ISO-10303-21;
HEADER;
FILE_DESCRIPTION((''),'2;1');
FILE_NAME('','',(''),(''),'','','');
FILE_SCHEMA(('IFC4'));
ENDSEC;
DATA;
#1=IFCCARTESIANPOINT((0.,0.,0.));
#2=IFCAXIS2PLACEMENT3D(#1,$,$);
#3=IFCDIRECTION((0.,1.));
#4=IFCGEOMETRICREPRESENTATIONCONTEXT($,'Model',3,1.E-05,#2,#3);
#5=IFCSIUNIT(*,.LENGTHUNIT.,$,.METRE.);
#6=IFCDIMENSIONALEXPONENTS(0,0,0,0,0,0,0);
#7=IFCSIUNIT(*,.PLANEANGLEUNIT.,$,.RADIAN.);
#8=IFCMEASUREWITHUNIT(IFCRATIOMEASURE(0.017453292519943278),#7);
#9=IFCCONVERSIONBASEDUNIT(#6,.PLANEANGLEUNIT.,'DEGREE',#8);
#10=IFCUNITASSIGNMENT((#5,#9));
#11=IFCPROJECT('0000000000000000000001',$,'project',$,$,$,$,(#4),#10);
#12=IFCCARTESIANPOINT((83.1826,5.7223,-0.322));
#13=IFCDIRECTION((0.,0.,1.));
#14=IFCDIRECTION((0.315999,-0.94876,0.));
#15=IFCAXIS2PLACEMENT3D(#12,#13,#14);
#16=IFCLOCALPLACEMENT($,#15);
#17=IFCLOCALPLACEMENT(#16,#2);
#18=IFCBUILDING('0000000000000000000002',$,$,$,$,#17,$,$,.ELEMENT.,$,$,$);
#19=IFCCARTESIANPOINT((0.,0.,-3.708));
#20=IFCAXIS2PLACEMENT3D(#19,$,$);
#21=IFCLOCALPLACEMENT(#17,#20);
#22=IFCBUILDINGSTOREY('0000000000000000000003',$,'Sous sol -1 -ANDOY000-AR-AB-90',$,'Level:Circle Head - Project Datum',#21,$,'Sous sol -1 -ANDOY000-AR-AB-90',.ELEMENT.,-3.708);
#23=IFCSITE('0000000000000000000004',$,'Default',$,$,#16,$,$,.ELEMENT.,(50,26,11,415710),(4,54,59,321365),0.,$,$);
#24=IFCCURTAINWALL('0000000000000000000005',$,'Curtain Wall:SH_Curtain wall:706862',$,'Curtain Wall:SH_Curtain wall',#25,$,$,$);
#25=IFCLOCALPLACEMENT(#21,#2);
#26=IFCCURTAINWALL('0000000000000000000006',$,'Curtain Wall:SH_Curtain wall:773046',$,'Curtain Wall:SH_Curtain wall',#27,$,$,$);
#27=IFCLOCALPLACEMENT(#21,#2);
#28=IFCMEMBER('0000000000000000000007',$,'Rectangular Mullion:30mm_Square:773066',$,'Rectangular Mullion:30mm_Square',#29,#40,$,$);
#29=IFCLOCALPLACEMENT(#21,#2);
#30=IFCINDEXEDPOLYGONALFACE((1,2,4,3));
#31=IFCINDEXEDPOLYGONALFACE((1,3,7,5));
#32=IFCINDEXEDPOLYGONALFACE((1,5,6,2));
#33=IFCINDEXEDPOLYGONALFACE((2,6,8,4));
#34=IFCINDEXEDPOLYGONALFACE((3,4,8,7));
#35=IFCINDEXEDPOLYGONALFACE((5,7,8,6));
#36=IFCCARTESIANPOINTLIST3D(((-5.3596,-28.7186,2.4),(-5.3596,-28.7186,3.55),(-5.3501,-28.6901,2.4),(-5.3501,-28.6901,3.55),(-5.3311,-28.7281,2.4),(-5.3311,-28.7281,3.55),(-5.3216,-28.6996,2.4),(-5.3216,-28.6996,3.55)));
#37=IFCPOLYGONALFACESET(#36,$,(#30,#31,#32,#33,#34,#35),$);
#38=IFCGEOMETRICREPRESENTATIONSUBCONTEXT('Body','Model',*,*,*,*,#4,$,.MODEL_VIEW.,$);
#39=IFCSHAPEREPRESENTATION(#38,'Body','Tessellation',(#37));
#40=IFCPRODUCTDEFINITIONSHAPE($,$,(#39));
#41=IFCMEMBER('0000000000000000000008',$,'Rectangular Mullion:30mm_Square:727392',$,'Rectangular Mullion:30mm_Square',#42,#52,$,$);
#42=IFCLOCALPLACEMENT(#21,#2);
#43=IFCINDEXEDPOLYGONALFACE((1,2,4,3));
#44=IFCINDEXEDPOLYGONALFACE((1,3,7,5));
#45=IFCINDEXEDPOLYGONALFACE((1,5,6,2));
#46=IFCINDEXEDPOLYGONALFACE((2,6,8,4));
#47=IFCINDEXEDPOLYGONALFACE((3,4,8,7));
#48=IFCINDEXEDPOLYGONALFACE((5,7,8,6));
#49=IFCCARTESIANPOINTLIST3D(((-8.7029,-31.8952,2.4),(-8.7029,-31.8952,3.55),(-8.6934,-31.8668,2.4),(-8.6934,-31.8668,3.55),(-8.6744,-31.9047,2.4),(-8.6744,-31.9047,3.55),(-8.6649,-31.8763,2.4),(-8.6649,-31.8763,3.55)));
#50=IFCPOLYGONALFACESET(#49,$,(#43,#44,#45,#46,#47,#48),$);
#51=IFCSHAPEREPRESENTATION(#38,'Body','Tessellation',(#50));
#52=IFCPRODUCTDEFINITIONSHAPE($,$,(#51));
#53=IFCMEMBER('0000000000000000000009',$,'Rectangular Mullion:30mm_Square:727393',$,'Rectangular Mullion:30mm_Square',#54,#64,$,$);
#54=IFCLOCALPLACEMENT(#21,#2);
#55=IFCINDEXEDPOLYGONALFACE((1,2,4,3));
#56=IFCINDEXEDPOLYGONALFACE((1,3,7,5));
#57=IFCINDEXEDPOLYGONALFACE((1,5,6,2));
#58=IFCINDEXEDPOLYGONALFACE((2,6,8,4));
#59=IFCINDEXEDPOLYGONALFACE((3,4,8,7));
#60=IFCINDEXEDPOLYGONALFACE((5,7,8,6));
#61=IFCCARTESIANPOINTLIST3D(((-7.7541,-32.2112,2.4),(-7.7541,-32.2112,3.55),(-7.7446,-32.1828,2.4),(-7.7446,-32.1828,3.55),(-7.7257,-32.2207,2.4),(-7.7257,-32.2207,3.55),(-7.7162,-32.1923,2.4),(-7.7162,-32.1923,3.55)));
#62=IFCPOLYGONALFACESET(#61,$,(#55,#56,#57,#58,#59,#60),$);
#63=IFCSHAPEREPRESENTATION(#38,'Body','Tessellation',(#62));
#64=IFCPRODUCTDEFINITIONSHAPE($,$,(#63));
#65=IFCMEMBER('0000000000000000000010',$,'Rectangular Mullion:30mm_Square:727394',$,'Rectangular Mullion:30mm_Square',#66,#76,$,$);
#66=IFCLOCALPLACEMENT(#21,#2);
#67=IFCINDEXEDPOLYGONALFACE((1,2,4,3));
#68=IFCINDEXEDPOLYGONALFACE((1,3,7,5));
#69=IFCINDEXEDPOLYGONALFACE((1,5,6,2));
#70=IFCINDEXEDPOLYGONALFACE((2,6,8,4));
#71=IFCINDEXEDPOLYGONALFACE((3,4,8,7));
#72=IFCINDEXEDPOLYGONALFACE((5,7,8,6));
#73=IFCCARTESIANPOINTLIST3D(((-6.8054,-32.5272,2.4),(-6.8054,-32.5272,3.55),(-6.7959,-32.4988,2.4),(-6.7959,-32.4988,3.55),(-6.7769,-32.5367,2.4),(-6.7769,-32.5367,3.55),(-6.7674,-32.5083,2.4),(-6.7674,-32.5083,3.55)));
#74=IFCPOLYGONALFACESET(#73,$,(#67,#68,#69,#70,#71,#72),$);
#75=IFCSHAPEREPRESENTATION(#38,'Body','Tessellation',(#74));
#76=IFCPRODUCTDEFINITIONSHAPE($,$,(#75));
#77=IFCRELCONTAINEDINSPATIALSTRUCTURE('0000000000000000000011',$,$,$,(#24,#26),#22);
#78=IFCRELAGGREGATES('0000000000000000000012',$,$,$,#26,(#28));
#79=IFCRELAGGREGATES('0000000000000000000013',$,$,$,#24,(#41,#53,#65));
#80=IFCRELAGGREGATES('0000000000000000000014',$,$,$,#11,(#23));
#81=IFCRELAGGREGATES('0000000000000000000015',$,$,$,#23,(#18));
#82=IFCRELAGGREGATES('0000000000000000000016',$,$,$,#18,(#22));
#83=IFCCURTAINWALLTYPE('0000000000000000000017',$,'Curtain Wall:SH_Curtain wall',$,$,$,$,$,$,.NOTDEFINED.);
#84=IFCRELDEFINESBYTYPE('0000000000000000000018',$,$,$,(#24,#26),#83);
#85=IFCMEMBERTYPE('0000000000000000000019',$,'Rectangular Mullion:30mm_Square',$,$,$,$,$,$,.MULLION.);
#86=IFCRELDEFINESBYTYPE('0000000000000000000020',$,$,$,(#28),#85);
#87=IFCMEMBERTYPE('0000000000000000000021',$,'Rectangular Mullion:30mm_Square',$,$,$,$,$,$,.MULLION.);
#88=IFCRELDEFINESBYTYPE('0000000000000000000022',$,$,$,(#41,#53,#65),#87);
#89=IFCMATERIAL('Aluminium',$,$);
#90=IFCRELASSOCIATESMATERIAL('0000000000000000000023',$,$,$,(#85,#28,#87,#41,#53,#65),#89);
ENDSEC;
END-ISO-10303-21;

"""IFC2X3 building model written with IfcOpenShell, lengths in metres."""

from ifc_helpers import new_model, entity, si_unit, converted_unit, direction, frame, origin, origin_2d_with_axis, place, context, subcontext, project, spatial, rectangle, extrude, source, transform, mapped, material, type_object, type_shapes, element, aggregate, save


model = new_model("IFC2X3")

# Units and contexts
model_context = context("Model", 3, precision=1e-05, world=origin(), true_north=direction((0.0, 1.0)))
body_context = subcontext(model_context, "Body", "Model", "MODEL_VIEW")
ifc_project = project(units=[si_unit("LENGTHUNIT", "METRE"), converted_unit("PLANEANGLEUNIT", "DEGREE", entity("IfcRatioMeasure", 0.017453292519943278), si_unit("PLANEANGLEUNIT", "RADIAN"), dimensions=[0, 0, 0, 0, 0, 0, 0])], contexts=[model_context])

# Site, building, storey
site_placement = place(None, frame((83.1826, 5.7223, -0.322), z_axis=(0.0, 0.0, 1.0), x_axis=(0.315999, -0.94876, 0.0)))
site = spatial("IfcSite", under=ifc_project, at=site_placement, Name="Default", CompositionType="ELEMENT", RefLatitude=(50, 26, 11, 415710), RefLongitude=(4, 54, 59, 321365), RefElevation=0.0)
building_placement = place(site_placement, origin())
building = spatial("IfcBuilding", under=site, at=building_placement, CompositionType="ELEMENT")
storey_placement = place(building_placement, frame((0.0, 0.0, -3.708)))
storey = spatial("IfcBuildingStorey", under=building, at=storey_placement, Name="Sous sol -1 -ANDOY000-AR-AB-90", ObjectType="Level:Circle Head - Project Datum", LongName="Sous sol -1 -ANDOY000-AR-AB-90", CompositionType="ELEMENT", Elevation=-3.708)

# Curtain wall
curtain_wall_type = type_object("IfcCurtainWallType", Name="Curtain Wall:SH_Curtain wall", PredefinedType="NOTDEFINED")
curtain_wall_1_placement = place(storey_placement, frame((0.0, 0.0, 3.708)))
curtain_wall_1 = element("IfcCurtainWall", 1, at=curtain_wall_1_placement, inside=storey, type_object=curtain_wall_type, Name="Curtain Wall:SH_Curtain wall:706862", ObjectType="Curtain Wall:SH_Curtain wall")
ifc_material_1 = material(Name="Aluminium")

# Curtain wall, member
curtain_wall_2_placement = place(storey_placement, frame((0.0, 0.0, 3.708)))
curtain_wall_2 = element("IfcCurtainWall", 2, at=curtain_wall_2_placement, inside=storey, type_object=curtain_wall_type, Name="Curtain Wall:SH_Curtain wall:773046", ObjectType="Curtain Wall:SH_Curtain wall")
member_type_1 = type_object("IfcMemberType", Name="Rectangular Mullion:30mm_Square", PredefinedType="MULLION", material=ifc_material_1)
shared_shape_1 = source(origin(), body_context, "Body", "SweptSolid", [
    extrude(rectangle(XDim=0.03, YDim=0.03, at=origin_2d_with_axis()), frame((-0.015, 0.0, -1.15), z_axis=(0.0, 0.0, 1.0), x_axis=(0.0, -1.0, 0.0)), (0.0, 0.0, 1.0), 1.15),
])
type_shapes(member_type_1, [shared_shape_1])
member_1_placement = place(curtain_wall_2_placement, frame((-5.3264, -28.7138, -1.308), z_axis=(0.0, 0.0, -1.0), x_axis=(0.948759, -0.316, 0.0)))
member_1 = element("IfcMember", 3, at=member_1_placement, type_object=member_type_1, material=ifc_material_1, Name="Rectangular Mullion:30mm_Square:773066", ObjectType="Rectangular Mullion:30mm_Square", context=body_context, shape_type="MappedRepresentation", body=[
    mapped(shared_shape_1, transform((0.0, 0.0, 0.0), scale=1.0)),
])
aggregate(curtain_wall_2, [member_1])

# Members
member_type_2 = type_object("IfcMemberType", Name="Rectangular Mullion:30mm_Square", PredefinedType="MULLION", material=ifc_material_1)
shared_shape_2 = source(origin(), body_context, "Body", "SweptSolid", [
    extrude(rectangle(XDim=0.03, YDim=0.03, at=origin_2d_with_axis()), frame((0.0, 0.0, -1.15), z_axis=(0.0, 0.0, 1.0), x_axis=(0.0, -1.0, 0.0)), (0.0, 0.0, 1.0), 1.15),
])
type_shapes(member_type_2, [shared_shape_2])
member_2_placement = place(curtain_wall_1_placement, frame((-8.6839, -31.8858, -1.308), z_axis=(0.0, 0.0, -1.0), x_axis=(0.948759, -0.316, 0.0)))
member_2 = element("IfcMember", 4, at=member_2_placement, type_object=member_type_2, material=ifc_material_1, Name="Rectangular Mullion:30mm_Square:727392", ObjectType="Rectangular Mullion:30mm_Square", context=body_context, shape_type="MappedRepresentation", body=[
    mapped(shared_shape_2, transform((0.0, 0.0, 0.0), scale=1.0)),
])
member_3_placement = place(curtain_wall_1_placement, frame((-7.7351, -32.2018, -1.308), z_axis=(0.0, 0.0, -1.0), x_axis=(0.948759, -0.316, 0.0)))
member_3 = element("IfcMember", 5, at=member_3_placement, type_object=member_type_2, material=ifc_material_1, Name="Rectangular Mullion:30mm_Square:727393", ObjectType="Rectangular Mullion:30mm_Square", context=body_context, shape_type="MappedRepresentation", body=[
    mapped(shared_shape_2, transform((0.0, 0.0, 0.0), scale=1.0)),
])
member_4_placement = place(curtain_wall_1_placement, frame((-6.7864, -32.5178, -1.308), z_axis=(0.0, 0.0, -1.0), x_axis=(0.948759, -0.316, 0.0)))
member_4 = element("IfcMember", 6, at=member_4_placement, type_object=member_type_2, material=ifc_material_1, Name="Rectangular Mullion:30mm_Square:727394", ObjectType="Rectangular Mullion:30mm_Square", context=body_context, shape_type="MappedRepresentation", body=[
    mapped(shared_shape_2, transform((0.0, 0.0, 0.0), scale=1.0)),
])

aggregate(curtain_wall_1, [member_2, member_3, member_4])

save(model, "model.ifc")
